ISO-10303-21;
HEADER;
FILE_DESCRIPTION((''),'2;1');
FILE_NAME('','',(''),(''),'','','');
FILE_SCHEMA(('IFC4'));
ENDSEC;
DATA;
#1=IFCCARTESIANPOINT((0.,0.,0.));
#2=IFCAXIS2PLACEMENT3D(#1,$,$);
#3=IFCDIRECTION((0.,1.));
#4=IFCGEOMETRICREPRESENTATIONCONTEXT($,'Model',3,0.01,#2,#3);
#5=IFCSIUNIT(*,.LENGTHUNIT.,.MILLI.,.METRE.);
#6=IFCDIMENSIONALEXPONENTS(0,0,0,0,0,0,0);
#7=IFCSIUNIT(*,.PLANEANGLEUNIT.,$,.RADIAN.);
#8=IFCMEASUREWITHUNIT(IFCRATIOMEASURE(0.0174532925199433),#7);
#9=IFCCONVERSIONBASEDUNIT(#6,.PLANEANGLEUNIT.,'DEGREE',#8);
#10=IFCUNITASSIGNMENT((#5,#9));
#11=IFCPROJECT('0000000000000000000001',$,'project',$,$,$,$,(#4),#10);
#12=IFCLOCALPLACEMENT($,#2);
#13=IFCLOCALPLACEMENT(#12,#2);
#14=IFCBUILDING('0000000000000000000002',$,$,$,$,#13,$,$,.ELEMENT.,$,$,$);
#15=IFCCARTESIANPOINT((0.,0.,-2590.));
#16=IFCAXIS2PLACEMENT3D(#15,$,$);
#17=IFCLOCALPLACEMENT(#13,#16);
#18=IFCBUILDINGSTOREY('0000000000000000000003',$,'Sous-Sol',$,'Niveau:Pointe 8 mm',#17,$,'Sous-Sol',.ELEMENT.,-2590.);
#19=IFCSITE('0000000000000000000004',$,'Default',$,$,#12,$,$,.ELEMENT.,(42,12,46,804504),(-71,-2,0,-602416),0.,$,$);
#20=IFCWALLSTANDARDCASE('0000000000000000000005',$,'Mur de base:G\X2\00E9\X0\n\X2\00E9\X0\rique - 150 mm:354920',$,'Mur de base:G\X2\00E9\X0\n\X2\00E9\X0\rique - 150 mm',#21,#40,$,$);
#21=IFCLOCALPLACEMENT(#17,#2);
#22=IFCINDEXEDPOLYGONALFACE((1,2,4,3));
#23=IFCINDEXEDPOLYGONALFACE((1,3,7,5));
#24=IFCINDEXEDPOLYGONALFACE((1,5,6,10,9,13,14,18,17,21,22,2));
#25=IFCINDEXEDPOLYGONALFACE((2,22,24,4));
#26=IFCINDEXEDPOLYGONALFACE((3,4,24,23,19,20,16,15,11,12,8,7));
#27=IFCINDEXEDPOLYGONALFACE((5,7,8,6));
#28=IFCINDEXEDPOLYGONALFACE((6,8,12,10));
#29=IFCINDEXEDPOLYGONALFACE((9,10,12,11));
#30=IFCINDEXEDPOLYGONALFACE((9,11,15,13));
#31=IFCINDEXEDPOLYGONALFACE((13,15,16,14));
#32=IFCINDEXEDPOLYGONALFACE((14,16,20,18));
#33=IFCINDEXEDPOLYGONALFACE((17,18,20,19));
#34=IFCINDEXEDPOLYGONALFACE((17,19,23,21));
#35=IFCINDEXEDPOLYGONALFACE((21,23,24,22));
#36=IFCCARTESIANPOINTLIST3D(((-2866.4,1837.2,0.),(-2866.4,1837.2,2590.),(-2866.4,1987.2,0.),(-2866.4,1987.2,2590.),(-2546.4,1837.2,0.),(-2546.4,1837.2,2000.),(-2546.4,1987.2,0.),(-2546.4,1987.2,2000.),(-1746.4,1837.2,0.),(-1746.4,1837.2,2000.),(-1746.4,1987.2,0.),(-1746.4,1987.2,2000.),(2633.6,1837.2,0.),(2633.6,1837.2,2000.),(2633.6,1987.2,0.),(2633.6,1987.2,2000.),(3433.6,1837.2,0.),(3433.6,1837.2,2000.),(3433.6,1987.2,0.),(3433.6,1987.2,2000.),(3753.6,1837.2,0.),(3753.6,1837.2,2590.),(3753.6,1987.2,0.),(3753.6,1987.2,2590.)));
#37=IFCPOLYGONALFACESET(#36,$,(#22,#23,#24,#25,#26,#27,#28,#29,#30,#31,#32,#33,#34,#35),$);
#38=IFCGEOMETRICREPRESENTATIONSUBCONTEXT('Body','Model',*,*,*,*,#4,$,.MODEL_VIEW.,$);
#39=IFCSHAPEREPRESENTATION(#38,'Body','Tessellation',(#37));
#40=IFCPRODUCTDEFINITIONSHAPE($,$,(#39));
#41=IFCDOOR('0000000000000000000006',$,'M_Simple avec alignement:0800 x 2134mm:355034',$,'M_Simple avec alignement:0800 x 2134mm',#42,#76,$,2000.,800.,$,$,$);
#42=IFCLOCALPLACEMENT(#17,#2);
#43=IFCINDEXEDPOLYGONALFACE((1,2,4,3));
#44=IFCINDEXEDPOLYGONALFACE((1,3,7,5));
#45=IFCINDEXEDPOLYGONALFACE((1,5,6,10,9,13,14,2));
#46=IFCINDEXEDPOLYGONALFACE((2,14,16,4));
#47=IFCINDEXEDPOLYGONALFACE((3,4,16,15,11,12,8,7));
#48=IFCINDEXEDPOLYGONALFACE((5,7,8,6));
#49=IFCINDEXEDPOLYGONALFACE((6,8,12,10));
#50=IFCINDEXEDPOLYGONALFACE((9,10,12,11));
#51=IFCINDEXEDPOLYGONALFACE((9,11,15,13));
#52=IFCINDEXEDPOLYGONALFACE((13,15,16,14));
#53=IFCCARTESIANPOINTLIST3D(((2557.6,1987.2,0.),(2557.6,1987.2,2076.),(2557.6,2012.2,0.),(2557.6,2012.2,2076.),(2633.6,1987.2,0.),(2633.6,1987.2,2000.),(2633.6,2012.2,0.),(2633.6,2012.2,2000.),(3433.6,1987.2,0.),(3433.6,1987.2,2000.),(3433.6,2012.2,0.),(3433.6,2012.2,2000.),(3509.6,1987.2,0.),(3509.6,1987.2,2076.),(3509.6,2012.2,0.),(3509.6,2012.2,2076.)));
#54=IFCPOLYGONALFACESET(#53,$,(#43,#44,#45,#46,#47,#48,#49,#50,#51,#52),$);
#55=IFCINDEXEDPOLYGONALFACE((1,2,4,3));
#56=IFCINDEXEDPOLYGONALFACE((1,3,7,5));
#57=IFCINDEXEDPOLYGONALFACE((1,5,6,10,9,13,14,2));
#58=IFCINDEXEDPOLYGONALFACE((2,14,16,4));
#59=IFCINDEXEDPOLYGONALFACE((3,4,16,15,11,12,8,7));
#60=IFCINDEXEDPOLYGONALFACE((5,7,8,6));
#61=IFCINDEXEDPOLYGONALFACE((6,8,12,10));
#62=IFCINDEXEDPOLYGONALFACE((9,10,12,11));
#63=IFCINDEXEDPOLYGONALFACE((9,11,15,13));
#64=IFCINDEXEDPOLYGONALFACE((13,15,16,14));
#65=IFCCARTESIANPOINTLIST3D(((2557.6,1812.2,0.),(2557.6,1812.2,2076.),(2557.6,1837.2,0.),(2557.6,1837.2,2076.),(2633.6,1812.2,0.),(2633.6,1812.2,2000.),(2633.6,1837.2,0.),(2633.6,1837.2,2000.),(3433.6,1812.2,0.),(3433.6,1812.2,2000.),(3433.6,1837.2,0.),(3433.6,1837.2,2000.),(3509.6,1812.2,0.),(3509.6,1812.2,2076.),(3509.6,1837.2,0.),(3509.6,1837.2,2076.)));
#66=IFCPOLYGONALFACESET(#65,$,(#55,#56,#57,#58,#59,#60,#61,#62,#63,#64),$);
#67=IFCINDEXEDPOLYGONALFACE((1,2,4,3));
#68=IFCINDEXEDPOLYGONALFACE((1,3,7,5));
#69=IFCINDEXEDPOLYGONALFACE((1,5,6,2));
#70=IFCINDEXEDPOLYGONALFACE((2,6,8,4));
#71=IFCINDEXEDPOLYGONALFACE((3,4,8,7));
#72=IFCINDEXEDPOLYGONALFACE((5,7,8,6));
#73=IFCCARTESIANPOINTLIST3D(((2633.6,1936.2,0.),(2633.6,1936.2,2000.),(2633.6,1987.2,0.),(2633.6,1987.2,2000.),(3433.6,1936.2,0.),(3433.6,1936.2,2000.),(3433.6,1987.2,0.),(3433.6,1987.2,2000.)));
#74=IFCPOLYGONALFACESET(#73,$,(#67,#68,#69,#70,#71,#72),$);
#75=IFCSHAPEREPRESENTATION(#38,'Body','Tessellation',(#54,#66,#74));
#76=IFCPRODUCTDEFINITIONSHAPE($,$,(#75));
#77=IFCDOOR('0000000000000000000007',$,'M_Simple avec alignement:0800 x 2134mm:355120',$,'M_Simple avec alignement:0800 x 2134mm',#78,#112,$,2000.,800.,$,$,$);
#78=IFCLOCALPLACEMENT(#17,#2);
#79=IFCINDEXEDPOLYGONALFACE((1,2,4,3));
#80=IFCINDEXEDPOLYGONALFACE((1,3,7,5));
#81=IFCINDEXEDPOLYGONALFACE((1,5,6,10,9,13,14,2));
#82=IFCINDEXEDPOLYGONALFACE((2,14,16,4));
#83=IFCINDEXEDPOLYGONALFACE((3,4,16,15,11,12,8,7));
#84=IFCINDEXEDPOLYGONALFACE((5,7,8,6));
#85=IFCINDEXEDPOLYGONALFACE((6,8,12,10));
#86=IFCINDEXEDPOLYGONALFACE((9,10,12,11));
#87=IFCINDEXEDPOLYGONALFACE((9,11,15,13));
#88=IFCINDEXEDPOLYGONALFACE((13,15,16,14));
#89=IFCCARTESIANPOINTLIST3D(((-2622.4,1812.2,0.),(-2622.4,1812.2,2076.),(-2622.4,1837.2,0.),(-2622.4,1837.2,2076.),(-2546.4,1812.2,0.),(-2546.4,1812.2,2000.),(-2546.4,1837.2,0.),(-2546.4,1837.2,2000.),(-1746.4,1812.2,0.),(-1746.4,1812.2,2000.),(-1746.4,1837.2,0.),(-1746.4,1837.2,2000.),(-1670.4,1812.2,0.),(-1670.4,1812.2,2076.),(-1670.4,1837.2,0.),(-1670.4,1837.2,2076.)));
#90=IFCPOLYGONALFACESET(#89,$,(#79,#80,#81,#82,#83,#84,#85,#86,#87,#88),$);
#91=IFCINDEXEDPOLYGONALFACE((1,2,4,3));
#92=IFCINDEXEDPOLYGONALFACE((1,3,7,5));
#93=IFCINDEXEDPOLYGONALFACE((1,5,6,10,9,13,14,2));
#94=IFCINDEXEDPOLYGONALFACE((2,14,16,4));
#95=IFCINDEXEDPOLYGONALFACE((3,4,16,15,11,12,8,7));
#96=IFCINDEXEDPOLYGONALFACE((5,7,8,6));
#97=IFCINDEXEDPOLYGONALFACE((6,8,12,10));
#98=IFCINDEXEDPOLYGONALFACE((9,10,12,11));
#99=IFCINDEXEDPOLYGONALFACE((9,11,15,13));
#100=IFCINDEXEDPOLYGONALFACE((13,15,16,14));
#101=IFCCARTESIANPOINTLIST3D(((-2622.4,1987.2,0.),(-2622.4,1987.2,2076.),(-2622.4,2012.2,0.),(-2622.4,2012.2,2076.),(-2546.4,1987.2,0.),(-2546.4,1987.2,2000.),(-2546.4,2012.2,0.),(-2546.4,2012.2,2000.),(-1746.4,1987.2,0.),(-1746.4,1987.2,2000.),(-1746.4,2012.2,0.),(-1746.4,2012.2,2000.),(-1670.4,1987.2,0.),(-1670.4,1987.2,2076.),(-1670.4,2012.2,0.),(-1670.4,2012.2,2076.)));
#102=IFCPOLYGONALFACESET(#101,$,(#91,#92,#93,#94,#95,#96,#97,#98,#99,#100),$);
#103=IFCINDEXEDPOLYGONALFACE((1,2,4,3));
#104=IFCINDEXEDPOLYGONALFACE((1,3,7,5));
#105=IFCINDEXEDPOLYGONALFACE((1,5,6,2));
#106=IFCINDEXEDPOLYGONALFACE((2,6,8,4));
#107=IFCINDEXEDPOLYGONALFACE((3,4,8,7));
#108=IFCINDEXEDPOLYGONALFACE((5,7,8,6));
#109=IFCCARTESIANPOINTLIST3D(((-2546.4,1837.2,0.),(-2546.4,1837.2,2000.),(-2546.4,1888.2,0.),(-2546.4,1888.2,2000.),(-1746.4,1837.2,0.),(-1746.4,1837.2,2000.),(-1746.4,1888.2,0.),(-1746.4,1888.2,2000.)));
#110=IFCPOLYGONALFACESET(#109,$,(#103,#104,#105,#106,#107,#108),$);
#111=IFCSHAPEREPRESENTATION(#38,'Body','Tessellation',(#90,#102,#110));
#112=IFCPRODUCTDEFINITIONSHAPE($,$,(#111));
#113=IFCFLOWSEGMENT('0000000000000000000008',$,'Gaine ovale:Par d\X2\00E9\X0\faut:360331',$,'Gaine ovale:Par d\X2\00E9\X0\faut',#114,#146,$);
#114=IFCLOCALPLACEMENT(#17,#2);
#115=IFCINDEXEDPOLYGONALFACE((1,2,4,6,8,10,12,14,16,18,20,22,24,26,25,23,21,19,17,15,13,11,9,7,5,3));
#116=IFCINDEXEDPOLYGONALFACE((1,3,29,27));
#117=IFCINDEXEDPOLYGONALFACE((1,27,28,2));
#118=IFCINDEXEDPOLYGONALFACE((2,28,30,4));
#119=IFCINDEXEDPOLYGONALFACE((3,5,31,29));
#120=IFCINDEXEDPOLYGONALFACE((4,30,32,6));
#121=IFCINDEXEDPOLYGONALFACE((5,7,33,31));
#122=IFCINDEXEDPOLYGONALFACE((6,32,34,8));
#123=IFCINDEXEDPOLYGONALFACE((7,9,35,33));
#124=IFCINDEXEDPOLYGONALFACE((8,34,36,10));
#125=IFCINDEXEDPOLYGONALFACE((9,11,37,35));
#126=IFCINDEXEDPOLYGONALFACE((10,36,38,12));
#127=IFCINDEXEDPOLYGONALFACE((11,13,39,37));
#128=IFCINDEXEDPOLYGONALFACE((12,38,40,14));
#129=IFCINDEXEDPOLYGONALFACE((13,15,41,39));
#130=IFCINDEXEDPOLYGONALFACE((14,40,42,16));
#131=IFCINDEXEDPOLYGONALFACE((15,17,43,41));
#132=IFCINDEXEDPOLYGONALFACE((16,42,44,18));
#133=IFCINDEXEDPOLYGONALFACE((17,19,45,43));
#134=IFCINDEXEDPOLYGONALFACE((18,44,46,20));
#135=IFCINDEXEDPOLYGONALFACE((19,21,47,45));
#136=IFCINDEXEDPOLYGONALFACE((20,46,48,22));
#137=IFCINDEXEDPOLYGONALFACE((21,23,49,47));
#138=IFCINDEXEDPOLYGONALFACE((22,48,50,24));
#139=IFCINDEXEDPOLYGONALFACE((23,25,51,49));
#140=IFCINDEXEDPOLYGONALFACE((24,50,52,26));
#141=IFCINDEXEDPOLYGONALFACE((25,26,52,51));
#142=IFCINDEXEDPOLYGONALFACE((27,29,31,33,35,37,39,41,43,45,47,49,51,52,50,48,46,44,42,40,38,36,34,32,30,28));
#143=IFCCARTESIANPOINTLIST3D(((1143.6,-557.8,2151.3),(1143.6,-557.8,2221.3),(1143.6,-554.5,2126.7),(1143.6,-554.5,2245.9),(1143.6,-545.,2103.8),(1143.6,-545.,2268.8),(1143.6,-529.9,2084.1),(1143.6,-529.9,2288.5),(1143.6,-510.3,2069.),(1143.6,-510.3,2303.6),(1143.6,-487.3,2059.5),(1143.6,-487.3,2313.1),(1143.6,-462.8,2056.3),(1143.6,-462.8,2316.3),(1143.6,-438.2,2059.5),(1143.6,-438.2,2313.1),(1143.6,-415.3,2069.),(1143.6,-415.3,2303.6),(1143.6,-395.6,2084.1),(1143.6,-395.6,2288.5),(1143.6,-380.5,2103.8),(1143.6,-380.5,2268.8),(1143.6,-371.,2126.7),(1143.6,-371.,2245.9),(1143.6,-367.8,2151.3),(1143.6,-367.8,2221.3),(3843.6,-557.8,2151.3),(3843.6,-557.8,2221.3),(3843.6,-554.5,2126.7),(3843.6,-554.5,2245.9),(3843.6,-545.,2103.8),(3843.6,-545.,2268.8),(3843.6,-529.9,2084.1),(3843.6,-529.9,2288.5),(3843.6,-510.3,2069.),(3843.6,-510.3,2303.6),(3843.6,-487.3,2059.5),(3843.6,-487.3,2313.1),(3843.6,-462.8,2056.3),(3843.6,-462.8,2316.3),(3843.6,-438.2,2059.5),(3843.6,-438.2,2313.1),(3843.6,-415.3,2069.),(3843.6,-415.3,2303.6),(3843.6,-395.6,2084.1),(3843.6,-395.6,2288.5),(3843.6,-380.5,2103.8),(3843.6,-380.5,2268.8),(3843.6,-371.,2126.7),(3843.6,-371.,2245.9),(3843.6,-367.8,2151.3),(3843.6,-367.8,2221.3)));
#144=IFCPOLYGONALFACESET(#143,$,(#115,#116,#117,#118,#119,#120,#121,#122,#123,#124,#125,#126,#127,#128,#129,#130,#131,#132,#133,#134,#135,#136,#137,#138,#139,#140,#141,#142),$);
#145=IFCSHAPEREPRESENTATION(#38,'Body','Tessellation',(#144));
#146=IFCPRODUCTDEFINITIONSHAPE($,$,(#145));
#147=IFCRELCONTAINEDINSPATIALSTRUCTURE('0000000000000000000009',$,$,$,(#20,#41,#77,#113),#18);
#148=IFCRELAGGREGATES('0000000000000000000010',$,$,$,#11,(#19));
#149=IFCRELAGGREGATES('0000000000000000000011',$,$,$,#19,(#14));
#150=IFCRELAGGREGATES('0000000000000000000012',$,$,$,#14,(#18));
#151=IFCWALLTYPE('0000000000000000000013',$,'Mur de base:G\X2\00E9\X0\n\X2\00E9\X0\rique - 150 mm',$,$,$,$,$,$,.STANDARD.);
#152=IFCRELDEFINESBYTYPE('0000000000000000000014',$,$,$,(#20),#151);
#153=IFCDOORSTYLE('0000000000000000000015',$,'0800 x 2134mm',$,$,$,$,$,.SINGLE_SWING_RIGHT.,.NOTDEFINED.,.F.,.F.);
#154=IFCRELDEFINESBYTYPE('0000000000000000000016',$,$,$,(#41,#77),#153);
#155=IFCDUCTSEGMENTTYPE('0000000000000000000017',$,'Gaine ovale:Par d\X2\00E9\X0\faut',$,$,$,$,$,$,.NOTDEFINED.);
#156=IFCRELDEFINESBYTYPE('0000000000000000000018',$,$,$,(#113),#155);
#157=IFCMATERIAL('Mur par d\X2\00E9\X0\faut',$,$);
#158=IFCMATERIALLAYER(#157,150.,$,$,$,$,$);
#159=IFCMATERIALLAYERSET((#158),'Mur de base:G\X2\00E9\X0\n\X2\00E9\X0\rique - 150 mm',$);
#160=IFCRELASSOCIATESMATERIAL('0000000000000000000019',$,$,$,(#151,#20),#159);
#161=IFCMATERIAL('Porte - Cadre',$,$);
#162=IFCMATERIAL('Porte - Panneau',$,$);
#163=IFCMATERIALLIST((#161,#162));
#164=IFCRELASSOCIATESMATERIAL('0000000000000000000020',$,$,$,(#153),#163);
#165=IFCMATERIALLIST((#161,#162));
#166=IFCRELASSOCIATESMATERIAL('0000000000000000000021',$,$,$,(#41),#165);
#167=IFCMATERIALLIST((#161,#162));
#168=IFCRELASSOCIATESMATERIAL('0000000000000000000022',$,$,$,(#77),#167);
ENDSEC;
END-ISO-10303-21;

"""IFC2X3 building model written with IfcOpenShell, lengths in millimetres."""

from ifc_helpers import new_model, entity, si_unit, converted_unit, direction, frame, frame_2d, origin, place, context, subcontext, project, spatial, polyline, circle_curve, parameter, trimmed, segment, composite_curve, rectangle, outline, extrude, source, transform, mapped, material, material_list, layer, layer_set, layer_usage, type_object, type_shapes, element, fill, save


model = new_model("IFC2X3")

# Units and contexts
model_context = context("Model", 3, precision=0.01, world=origin(), true_north=direction((0.0, 1.0)))
body_context = subcontext(model_context, "Body", "Model", "MODEL_VIEW")
ifc_project = project(units=[si_unit("LENGTHUNIT", "METRE", prefix="MILLI"), converted_unit("PLANEANGLEUNIT", "DEGREE", entity("IfcRatioMeasure", 0.0174532925199433), si_unit("PLANEANGLEUNIT", "RADIAN"), dimensions=[0, 0, 0, 0, 0, 0, 0])], contexts=[model_context])

# Site, building, storey
site_placement = place(None, origin())
site = spatial("IfcSite", under=ifc_project, at=site_placement, Name="Default", CompositionType="ELEMENT", RefLatitude=(42, 12, 46, 804504), RefLongitude=(-71, -2, 0, -602416), RefElevation=0.0)
building_placement = place(site_placement, origin())
building = spatial("IfcBuilding", under=site, at=building_placement, CompositionType="ELEMENT")
storey_placement = place(building_placement, frame((0.0, 0.0, -2590.0)))
storey = spatial("IfcBuildingStorey", under=building, at=storey_placement, Name="Sous-Sol", ObjectType="Niveau:Pointe 8 mm", LongName="Sous-Sol", CompositionType="ELEMENT", Elevation=-2590.0)

# Shared definitions
ifc_material_1 = material(Name="Mur par défaut")

# Shared definitions
ifc_layer_1 = layer(ifc_material_1, 150.0)
ifc_layer_set_1 = layer_set([ifc_layer_1], Name="Mur de base:Générique - 150 mm")
wall_type_1 = type_object("IfcWallType", Name="Mur de base:Générique - 150 mm", PredefinedType="STANDARD", material=ifc_layer_set_1)
ifc_material_2 = material(Name="Porte - Cadre")
ifc_material_3 = material(Name="Porte - Panneau")
ifc_material_list_1 = material_list([ifc_material_2, ifc_material_3])
door_style = type_object("IfcDoorStyle", Name="0800 x 2134mm", ConstructionType="NOTDEFINED", OperationType="SINGLE_SWING_RIGHT", ParameterTakesPrecedence=False, Sizeable=False, material=ifc_material_list_1)
shared_shape_1 = source(origin(), body_context, "Body", "SweptSolid", [
    extrude(outline(polyline([(-476.0, -1057.0), (476.0, -1057.0), (476.0, 1019.0), (400.0, 1019.0), (400.0, -981.0), (-400.0, -981.0), (-400.0, 1019.0), (-476.0, 1019.0), (-476.0, -1057.0)])), frame((400.0, 150.0, 1019.0), z_axis=(0.0, 1.0, 0.0), x_axis=(1.0, 0.0, 0.0)), (0.0, 0.0, 1.0), 25.0),
    extrude(outline(polyline([(-1057.0, -476.0), (1019.0, -476.0), (1019.0, -400.0), (-981.0, -400.0), (-981.0, 400.0), (1019.0, 400.0), (1019.0, 476.0), (-1057.0, 476.0), (-1057.0, -476.0)])), frame((400.0, -25.0, 1019.0), z_axis=(0.0, 1.0, 0.0), x_axis=(0.0, 0.0, -1.0)), (0.0, 0.0, 1.0), 25.0),
    extrude(rectangle(XDim=51.0, YDim=800.0, at=frame_2d((0.0, 0.0), x_axis=(1.0, 0.0))), frame((400.0, 124.5, 0.0), z_axis=(0.0, 0.0, 1.0), x_axis=(0.0, 1.0, 0.0)), (0.0, 0.0, 1.0), 2000.0),
])
type_shapes(door_style, [shared_shape_1])

# Wall, openings, doors
ifc_layer_usage_1 = layer_usage(ifc_layer_set_1, "AXIS2", "NEGATIVE", 75.0)
wall_1_placement = place(storey_placement, frame((3753.6, 1912.2, 0.0), z_axis=(0.0, 0.0, 1.0), x_axis=(-1.0, 0.0, 0.0)))
wall_1 = element("IfcWallStandardCase", 1, at=wall_1_placement, inside=storey, type_object=wall_type_1, material=ifc_layer_usage_1, Name="Mur de base:Générique - 150 mm:354920", ObjectType="Mur de base:Générique - 150 mm", context=body_context, shape_type="SweptSolid", body=[
    extrude(rectangle(XDim=6620.0, YDim=150.0, at=frame_2d((3310.0, 0.0), x_axis=(-1.0, 0.0))), origin(), (0.0, 0.0, 1.0), 2590.0),
])
opening_1_placement = place(wall_1_placement, frame((1120.0, 75.0, 0.0)))
opening_1 = element("IfcOpeningElement", 2, at=opening_1_placement, cuts=wall_1, ObjectType="Opening", context=body_context, shape_type="SweptSolid", body=[
    extrude(rectangle(XDim=800.0, YDim=2000.0, at=frame_2d((1000.0, 400.0), x_axis=(0.0, 1.0))), frame((0.0, 0.0, 0.0), z_axis=(0.0, -1.0, 0.0), x_axis=(0.0, 0.0, 1.0)), (0.0, 0.0, 1.0), 150.0),
])
opening_2_placement = place(wall_1_placement, frame((5500.0, -75.0, 0.0)))
opening_2 = element("IfcOpeningElement", 3, at=opening_2_placement, cuts=wall_1, ObjectType="Opening", context=body_context, shape_type="SweptSolid", body=[
    extrude(rectangle(XDim=800.0, YDim=2000.0, at=frame_2d((1000.0, 400.0), x_axis=(0.0, 1.0))), frame((0.0, 0.0, 0.0), z_axis=(0.0, 1.0, 0.0), x_axis=(0.0, 0.0, 1.0)), (0.0, 0.0, 1.0), 150.0),
])
ifc_material_list_2 = material_list([ifc_material_2, ifc_material_3])
door_1_placement = place(opening_1_placement, frame((0.0, 0.0, 0.0), z_axis=(0.0, 0.0, 1.0), x_axis=(-1.0, 0.0, 0.0)))
door_1 = element("IfcDoor", 4, at=door_1_placement, inside=storey, type_object=door_style, material=ifc_material_list_2, Name="M_Simple avec alignement:0800 x 2134mm:355034", ObjectType="M_Simple avec alignement:0800 x 2134mm", OverallHeight=2000.0, OverallWidth=800.0, context=body_context, shape_type="MappedRepresentation", body=[
    mapped(shared_shape_1, transform((0.0, 0.0, 0.0), scale=1.0)),
])
fill(opening_1, door_1)
ifc_material_list_3 = material_list([ifc_material_2, ifc_material_3])
door_2_placement = place(opening_2_placement, origin())
door_2 = element("IfcDoor", 5, at=door_2_placement, inside=storey, type_object=door_style, material=ifc_material_list_3, Name="M_Simple avec alignement:0800 x 2134mm:355120", ObjectType="M_Simple avec alignement:0800 x 2134mm", OverallHeight=2000.0, OverallWidth=800.0, context=body_context, shape_type="MappedRepresentation", body=[
    mapped(shared_shape_1, transform((0.0, 0.0, 0.0), scale=1.0)),
])
fill(opening_2, door_2)

# Flow segment
duct_segment_type = type_object("IfcDuctSegmentType", Name="Gaine ovale:Par défaut", PredefinedType="NOTDEFINED")
flow_segment_placement = place(storey_placement, origin())
element("IfcFlowSegment", 6, at=flow_segment_placement, inside=storey, type_object=duct_segment_type, Name="Gaine ovale:Par défaut:360331", ObjectType="Gaine ovale:Par défaut", context=body_context, shape_type="SweptSolid", body=[
    extrude(outline(composite_curve([segment(polyline([(-35.0, -95.0), (35.0, -95.0)]), True, "CONTINUOUS"), segment(trimmed(circle_curve(frame_2d((35.0, 0.0), x_axis=(0.0, -1.0)), 95.0), [parameter(0.0)], [parameter(90.0)], True, "PARAMETER"), True, "CONTINUOUS"), segment(trimmed(circle_curve(frame_2d((35.0, 0.0), x_axis=(0.0, -1.0)), 95.0), [parameter(90.0)], [parameter(180.0)], True, "PARAMETER"), True, "CONTINUOUS"), segment(polyline([(35.0, 95.0), (-35.0, 95.0)]), True, "CONTINUOUS"), segment(trimmed(circle_curve(frame_2d((-35.0, 0.0), x_axis=(0.0, -1.0)), 95.0), [parameter(180.0)], [parameter(270.0)], True, "PARAMETER"), True, "CONTINUOUS"), segment(trimmed(circle_curve(frame_2d((-35.0, 0.0), x_axis=(0.0, -1.0)), 95.0), [parameter(270.0)], [parameter(0.0)], True, "PARAMETER"), True, "CONTINUOUS")], self_intersect=False)), frame((1143.6, -462.8, 2186.3), z_axis=(1.0, 0.0, 0.0), x_axis=(0.0, 0.0, 1.0)), (0.0, 0.0, 1.0), 2700.0),
])

save(model, "model.ifc")
